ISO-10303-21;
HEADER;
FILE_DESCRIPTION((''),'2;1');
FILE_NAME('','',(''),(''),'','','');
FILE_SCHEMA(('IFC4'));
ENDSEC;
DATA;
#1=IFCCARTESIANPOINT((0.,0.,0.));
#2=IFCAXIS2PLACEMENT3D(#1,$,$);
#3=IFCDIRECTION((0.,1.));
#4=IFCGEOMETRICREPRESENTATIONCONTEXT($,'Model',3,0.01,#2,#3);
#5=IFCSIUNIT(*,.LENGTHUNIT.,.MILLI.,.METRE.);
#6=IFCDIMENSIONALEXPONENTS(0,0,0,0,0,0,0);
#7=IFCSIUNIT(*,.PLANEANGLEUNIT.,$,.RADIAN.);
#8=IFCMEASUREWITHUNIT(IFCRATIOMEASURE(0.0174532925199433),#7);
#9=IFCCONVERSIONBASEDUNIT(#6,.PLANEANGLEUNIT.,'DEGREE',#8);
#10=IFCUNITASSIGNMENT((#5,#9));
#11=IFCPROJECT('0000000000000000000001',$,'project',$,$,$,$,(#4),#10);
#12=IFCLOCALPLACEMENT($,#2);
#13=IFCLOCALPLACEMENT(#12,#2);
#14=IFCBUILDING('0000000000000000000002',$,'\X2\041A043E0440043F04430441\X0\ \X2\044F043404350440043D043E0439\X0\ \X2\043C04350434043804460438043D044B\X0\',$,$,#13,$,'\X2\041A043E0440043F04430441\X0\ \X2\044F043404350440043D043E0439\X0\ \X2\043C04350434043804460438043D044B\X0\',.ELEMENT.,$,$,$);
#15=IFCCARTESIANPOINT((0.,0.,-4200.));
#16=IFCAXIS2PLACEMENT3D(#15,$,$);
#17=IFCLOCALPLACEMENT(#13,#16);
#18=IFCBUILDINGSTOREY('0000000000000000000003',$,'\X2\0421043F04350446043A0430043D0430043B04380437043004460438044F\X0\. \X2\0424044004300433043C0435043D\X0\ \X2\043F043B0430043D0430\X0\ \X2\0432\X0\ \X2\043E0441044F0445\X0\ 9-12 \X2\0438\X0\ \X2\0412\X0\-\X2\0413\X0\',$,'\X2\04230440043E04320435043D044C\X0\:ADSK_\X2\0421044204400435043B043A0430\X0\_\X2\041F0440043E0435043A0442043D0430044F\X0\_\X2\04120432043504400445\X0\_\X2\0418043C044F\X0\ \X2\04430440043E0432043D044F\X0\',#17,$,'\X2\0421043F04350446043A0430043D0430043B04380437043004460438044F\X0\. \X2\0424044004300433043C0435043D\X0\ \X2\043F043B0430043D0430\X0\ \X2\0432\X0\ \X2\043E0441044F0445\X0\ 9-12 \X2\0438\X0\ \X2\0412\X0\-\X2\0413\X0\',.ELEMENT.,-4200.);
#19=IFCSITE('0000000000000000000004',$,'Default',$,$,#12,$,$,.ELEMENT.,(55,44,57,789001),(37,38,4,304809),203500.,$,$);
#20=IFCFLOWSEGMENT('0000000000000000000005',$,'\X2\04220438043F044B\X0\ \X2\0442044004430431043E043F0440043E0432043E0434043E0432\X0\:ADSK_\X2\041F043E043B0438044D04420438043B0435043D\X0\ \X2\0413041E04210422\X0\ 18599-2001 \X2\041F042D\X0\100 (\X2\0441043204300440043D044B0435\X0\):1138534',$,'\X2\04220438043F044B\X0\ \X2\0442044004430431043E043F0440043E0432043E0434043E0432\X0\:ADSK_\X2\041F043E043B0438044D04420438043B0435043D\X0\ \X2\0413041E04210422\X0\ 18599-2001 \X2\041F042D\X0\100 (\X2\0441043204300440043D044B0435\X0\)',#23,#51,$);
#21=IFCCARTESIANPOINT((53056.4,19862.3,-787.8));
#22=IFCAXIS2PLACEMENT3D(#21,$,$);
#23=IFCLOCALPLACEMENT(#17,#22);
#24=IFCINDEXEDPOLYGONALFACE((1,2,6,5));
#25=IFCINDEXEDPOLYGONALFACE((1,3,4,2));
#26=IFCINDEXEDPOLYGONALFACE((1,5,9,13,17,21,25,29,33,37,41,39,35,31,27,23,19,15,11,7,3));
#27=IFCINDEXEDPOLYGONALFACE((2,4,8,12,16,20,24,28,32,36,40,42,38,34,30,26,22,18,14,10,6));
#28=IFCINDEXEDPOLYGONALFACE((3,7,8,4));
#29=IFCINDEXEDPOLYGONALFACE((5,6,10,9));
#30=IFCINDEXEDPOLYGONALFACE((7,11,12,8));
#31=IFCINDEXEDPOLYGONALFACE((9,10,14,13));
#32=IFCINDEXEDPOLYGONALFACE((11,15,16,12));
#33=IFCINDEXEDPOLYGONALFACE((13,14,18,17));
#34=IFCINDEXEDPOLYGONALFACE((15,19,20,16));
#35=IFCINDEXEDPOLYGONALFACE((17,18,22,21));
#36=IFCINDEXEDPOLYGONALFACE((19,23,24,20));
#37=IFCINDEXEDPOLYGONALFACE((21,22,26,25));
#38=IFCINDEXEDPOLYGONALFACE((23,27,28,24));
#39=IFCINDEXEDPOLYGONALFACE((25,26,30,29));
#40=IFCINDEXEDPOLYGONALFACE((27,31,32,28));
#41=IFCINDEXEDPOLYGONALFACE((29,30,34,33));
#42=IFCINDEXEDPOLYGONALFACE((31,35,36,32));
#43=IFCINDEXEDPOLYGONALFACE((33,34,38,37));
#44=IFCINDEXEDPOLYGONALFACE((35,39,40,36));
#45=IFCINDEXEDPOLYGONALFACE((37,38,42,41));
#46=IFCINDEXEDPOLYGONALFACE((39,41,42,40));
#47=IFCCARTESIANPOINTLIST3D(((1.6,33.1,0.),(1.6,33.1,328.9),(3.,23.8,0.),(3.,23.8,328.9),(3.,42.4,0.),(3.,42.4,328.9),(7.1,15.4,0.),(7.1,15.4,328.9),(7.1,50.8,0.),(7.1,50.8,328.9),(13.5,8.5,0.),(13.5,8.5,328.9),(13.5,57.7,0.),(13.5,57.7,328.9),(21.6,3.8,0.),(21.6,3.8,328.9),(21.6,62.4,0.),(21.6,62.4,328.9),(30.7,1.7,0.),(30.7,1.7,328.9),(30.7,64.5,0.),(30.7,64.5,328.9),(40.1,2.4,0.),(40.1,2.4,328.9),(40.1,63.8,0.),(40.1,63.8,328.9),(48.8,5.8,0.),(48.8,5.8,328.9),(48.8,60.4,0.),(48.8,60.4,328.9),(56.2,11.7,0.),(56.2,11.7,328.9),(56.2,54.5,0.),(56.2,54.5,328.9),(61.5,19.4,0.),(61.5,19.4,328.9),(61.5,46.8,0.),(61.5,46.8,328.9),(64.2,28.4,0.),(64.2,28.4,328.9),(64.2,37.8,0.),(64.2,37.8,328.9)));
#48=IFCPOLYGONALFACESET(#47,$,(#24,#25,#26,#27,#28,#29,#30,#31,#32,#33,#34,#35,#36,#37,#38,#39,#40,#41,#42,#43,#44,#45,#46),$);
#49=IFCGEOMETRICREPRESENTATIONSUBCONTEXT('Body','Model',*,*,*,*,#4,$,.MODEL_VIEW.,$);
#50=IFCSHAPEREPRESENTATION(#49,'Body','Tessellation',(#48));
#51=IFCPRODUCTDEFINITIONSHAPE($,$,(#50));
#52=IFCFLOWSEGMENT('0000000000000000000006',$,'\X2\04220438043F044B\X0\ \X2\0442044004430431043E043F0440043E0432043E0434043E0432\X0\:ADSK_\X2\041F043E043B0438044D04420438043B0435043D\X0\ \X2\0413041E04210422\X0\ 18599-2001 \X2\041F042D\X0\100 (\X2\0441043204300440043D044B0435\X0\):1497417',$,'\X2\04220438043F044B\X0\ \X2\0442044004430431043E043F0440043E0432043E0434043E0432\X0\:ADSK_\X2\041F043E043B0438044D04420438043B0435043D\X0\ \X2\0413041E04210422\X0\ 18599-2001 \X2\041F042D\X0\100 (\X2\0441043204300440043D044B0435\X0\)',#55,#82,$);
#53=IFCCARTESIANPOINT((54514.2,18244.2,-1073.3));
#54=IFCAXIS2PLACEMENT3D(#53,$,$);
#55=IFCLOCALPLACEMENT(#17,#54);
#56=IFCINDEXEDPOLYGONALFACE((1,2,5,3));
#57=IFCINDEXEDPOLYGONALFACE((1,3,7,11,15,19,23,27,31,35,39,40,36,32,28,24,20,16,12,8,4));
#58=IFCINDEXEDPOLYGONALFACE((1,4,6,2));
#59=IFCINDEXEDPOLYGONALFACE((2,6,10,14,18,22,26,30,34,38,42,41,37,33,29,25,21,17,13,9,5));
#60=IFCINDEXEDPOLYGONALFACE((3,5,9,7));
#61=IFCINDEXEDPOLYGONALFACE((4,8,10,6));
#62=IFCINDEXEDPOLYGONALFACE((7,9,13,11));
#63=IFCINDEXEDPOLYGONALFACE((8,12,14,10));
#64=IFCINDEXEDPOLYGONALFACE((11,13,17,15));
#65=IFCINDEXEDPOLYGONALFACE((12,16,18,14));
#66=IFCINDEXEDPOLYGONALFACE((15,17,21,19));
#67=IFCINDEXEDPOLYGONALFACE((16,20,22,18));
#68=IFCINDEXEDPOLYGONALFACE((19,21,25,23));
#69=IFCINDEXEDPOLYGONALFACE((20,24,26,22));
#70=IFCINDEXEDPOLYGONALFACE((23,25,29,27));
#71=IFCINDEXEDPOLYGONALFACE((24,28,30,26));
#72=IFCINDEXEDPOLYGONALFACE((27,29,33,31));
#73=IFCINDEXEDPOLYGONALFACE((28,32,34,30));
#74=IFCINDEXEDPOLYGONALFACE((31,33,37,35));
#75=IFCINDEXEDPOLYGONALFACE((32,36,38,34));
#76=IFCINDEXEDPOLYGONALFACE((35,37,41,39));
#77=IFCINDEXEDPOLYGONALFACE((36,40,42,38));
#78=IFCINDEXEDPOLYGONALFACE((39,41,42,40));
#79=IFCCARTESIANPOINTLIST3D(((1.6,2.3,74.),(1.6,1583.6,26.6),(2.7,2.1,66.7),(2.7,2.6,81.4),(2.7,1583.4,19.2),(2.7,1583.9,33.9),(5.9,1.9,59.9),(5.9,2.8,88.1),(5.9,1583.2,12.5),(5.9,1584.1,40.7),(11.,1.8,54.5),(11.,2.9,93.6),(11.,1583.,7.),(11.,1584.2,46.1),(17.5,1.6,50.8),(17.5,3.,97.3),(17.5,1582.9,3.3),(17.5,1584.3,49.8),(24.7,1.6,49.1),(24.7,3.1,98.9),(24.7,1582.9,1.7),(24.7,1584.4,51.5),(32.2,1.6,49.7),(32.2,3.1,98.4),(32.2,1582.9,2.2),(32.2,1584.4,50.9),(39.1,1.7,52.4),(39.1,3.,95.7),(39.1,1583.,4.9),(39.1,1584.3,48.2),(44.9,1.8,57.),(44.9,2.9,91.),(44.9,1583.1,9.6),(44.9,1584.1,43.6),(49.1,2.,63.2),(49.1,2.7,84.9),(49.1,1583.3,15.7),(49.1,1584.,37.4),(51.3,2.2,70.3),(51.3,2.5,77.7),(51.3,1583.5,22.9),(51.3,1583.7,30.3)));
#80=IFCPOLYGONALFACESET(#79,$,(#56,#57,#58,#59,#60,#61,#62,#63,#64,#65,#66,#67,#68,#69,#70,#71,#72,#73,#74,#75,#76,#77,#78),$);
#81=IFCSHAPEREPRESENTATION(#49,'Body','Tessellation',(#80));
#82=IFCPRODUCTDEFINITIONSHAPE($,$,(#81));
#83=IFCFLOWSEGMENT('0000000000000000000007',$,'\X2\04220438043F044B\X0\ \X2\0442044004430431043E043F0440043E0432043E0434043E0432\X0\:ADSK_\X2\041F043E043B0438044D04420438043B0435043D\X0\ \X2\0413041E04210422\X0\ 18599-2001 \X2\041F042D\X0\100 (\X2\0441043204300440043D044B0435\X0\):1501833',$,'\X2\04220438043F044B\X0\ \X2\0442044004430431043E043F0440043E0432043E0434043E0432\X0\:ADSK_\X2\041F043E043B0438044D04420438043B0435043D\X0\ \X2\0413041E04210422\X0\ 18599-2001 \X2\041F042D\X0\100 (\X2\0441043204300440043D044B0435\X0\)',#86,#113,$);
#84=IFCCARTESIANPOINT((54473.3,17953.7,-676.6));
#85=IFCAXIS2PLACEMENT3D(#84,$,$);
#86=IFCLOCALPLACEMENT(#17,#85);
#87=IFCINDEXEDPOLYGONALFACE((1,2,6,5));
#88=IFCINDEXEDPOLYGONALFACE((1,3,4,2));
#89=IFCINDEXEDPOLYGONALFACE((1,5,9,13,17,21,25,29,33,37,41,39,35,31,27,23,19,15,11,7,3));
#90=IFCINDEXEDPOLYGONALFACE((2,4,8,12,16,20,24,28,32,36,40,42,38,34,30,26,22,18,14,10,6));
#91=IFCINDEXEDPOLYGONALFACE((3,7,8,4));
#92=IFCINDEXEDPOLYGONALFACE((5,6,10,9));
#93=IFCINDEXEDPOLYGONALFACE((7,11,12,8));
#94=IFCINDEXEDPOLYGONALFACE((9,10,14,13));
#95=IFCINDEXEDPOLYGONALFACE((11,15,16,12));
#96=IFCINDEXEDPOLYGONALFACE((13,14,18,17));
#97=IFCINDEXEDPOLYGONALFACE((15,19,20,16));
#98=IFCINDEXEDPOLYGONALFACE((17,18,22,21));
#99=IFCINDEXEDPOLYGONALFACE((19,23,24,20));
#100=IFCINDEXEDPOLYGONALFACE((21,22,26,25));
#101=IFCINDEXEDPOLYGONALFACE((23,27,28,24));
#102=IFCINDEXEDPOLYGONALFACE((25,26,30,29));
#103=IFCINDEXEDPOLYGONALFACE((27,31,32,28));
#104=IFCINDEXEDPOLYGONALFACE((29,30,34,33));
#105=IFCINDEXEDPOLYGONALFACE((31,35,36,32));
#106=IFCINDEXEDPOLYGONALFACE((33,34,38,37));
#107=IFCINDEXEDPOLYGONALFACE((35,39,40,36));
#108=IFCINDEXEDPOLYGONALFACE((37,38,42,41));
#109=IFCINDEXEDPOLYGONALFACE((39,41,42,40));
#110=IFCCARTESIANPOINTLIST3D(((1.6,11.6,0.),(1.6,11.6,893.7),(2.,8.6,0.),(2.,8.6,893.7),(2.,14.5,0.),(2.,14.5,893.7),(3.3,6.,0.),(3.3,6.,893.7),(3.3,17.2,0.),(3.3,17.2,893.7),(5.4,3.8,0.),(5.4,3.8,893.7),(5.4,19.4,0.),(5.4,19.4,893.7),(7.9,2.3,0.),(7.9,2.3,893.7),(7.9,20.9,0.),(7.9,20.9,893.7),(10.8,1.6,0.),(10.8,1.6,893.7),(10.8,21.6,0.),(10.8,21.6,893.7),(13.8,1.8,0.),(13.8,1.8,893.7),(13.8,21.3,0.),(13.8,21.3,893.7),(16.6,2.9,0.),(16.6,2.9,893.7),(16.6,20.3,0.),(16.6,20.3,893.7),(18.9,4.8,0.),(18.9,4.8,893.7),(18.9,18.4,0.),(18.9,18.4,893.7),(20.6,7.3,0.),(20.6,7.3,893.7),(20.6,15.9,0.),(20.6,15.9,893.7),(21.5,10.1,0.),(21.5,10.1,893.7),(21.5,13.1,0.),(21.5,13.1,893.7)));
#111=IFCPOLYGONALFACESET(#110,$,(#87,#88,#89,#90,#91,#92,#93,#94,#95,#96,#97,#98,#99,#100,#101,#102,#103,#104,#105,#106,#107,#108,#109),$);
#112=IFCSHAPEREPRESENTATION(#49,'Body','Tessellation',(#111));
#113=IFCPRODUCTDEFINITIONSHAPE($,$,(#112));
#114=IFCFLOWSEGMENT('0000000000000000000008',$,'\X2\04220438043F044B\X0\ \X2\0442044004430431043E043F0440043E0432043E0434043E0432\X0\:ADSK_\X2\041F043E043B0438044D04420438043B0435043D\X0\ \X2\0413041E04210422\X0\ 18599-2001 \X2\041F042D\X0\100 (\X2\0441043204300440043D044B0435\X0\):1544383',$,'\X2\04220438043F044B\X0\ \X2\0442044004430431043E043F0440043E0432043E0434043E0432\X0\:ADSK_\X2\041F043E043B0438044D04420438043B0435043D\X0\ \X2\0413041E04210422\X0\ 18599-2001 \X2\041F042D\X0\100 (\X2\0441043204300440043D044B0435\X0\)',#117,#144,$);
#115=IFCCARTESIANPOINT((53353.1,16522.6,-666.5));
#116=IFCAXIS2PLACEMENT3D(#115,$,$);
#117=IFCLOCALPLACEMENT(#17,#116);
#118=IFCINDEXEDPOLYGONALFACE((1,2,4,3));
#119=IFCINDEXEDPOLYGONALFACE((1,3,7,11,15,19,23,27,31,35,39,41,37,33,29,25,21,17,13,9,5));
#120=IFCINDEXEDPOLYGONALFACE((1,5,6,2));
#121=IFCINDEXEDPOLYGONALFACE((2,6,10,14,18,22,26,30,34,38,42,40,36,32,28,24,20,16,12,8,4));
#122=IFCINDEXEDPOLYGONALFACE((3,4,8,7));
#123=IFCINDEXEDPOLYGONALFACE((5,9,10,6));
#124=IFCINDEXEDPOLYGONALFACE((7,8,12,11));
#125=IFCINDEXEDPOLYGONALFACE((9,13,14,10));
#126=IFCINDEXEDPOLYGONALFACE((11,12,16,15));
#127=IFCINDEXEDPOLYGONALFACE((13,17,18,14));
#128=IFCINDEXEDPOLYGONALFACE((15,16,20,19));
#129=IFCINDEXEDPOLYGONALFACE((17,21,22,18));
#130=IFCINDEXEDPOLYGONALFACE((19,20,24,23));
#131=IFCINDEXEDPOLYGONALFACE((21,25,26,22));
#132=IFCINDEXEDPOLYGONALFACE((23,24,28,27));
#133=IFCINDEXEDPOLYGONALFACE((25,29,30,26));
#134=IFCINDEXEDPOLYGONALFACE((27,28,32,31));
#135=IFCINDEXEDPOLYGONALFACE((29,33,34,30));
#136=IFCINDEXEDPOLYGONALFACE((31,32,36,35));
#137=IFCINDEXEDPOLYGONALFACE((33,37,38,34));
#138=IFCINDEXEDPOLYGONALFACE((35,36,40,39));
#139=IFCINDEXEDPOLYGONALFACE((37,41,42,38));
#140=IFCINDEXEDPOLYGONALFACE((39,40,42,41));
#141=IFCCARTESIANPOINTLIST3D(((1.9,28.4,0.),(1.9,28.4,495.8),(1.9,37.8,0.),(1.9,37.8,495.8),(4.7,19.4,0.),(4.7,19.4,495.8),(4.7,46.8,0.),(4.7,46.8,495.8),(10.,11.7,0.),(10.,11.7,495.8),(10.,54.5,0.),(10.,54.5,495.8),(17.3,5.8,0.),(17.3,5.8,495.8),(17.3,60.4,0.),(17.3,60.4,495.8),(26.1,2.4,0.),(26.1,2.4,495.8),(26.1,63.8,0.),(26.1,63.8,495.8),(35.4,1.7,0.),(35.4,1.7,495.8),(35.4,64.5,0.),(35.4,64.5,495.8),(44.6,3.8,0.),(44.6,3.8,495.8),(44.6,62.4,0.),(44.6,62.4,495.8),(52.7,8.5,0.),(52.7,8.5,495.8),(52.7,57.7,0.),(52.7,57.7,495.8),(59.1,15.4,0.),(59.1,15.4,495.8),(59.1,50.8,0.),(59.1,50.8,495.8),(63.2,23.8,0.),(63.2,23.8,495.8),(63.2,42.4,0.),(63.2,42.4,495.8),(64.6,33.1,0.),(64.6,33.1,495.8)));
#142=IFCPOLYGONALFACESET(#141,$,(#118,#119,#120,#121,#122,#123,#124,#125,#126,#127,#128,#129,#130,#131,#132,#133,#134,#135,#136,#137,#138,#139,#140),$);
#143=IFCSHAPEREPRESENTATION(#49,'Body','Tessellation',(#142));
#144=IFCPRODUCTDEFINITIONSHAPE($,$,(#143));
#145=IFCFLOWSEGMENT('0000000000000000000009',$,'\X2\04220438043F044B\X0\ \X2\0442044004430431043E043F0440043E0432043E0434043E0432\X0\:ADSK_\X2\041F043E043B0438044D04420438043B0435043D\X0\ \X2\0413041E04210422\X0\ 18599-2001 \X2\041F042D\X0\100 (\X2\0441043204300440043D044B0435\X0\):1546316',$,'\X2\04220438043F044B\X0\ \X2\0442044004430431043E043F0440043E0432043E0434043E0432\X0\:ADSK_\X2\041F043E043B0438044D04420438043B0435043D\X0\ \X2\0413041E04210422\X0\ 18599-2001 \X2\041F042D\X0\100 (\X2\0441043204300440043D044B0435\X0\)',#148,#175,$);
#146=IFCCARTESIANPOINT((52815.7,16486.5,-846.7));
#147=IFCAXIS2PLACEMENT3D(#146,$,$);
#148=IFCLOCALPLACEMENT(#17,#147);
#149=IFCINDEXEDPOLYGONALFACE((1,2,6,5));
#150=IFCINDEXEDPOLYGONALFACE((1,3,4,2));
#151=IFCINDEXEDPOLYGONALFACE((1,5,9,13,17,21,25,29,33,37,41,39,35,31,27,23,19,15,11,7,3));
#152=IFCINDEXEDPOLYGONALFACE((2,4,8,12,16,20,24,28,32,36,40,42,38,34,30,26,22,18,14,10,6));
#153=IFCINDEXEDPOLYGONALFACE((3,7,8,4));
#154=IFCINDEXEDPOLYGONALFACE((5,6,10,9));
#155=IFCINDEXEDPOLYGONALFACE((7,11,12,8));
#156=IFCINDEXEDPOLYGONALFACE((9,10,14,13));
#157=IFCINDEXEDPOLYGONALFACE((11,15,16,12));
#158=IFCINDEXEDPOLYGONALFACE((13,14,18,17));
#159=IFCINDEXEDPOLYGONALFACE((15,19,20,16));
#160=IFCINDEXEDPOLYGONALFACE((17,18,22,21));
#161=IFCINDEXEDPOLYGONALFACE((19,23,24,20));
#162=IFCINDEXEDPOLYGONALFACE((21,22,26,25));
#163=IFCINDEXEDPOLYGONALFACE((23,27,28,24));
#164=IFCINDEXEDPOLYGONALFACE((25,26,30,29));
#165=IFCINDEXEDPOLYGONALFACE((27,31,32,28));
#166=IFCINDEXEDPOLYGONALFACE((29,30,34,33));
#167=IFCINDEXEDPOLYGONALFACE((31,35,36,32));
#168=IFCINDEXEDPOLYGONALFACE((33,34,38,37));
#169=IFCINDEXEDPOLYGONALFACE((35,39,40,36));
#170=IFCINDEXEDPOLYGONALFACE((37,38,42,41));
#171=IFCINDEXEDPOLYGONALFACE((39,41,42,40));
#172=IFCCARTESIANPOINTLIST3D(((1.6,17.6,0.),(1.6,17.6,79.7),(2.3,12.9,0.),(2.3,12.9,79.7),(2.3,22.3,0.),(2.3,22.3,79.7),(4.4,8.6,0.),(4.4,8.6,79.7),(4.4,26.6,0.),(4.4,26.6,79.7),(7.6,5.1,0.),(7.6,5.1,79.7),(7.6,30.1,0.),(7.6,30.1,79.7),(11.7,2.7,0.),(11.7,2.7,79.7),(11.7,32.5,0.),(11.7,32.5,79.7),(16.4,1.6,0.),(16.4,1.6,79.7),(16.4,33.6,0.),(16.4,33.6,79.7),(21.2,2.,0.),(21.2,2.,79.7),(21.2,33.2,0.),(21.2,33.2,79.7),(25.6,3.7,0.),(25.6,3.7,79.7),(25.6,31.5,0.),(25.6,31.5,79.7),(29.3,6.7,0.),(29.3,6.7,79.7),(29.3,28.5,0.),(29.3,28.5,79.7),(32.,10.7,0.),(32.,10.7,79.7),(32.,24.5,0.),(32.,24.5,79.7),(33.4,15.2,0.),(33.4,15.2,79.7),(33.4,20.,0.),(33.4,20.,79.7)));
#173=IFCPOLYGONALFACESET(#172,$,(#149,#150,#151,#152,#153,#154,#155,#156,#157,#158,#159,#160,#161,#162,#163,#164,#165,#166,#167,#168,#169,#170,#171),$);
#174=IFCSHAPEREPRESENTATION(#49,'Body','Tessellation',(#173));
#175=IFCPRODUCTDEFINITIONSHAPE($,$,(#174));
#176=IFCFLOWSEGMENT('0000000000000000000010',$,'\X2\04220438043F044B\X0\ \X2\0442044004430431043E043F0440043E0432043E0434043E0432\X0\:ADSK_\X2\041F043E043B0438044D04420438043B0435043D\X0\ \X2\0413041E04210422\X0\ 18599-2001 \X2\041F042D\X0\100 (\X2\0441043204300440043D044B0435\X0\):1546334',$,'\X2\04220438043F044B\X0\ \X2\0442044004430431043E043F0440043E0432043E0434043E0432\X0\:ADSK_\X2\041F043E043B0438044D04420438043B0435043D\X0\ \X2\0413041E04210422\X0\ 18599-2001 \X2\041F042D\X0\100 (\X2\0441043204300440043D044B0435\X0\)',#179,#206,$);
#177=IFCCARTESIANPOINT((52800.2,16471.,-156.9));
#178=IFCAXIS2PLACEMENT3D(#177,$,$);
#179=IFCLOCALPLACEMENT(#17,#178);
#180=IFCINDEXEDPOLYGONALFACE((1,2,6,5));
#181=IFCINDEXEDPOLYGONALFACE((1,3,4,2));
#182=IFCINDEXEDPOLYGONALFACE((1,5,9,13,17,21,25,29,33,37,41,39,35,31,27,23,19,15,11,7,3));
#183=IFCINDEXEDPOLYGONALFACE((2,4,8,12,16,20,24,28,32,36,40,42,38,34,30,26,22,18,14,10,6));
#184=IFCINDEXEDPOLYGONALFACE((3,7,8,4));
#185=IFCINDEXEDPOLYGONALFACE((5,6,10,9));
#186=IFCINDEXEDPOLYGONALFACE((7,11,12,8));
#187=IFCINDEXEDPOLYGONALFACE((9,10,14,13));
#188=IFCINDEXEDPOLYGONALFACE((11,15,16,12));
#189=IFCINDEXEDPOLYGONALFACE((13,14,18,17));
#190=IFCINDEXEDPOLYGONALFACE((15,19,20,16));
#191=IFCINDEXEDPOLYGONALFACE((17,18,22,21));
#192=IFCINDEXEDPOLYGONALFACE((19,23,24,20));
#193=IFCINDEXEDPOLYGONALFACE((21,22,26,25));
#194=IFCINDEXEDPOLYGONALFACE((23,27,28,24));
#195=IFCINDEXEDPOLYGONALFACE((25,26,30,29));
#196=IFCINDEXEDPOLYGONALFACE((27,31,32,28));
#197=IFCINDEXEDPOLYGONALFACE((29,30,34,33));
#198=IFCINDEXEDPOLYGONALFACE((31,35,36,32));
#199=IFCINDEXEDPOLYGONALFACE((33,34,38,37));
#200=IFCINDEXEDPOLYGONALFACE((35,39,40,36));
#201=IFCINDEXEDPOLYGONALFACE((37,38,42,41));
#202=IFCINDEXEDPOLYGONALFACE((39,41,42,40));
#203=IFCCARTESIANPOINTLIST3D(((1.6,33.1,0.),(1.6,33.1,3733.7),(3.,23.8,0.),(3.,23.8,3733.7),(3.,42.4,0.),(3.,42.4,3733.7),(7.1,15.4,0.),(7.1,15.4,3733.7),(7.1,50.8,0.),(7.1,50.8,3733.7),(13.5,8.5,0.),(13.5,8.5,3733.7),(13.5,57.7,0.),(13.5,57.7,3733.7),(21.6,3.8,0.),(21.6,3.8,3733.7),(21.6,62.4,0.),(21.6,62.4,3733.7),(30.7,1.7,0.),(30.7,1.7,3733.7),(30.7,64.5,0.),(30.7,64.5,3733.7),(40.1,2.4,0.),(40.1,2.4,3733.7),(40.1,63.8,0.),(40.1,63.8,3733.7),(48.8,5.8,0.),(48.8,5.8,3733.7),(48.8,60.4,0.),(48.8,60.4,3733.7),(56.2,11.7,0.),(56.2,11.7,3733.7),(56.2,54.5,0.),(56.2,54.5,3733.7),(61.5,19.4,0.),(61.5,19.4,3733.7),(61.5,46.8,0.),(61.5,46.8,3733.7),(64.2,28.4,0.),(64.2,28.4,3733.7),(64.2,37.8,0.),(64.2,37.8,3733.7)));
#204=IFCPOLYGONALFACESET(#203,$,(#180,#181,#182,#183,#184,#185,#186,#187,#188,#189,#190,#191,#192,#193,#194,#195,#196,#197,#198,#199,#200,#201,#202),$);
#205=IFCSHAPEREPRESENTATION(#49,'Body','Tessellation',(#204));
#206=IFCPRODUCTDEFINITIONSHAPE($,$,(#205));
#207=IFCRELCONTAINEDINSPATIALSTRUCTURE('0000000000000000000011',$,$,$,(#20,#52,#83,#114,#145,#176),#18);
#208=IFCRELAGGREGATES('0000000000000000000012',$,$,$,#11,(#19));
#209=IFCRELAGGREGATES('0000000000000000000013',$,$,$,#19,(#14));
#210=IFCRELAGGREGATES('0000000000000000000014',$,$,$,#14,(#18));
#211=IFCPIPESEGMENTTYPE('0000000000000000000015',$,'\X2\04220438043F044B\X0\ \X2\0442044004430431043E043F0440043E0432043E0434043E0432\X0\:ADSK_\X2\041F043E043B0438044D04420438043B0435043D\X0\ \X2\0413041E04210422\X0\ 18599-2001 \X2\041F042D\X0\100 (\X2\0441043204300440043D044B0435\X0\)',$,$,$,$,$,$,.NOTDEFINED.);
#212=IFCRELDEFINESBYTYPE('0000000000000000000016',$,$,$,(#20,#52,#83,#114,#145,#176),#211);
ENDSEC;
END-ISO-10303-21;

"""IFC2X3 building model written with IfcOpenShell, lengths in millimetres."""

from ifc_helpers import new_model, entity, si_unit, converted_unit, direction, frame, frame_2d, origin, origin_2d_with_axis, place, context, subcontext, project, spatial, circle, extrude, type_object, element, save


model = new_model("IFC2X3")

# Units and contexts
model_context = context("Model", 3, precision=0.01, world=origin(), true_north=direction((0.0, 1.0)))
body_context = subcontext(model_context, "Body", "Model", "MODEL_VIEW")
ifc_project = project(units=[si_unit("LENGTHUNIT", "METRE", prefix="MILLI"), converted_unit("PLANEANGLEUNIT", "DEGREE", entity("IfcRatioMeasure", 0.0174532925199433), si_unit("PLANEANGLEUNIT", "RADIAN"), dimensions=[0, 0, 0, 0, 0, 0, 0])], contexts=[model_context])

# Site, building, storey
site_placement = place(None, frame((0.0, 0.0, 0.0)))
site = spatial("IfcSite", under=ifc_project, at=site_placement, Name="Default", CompositionType="ELEMENT", RefLatitude=(55, 44, 57, 789001), RefLongitude=(37, 38, 4, 304809), RefElevation=203500.0)
building_placement = place(site_placement, origin())
building = spatial("IfcBuilding", under=site, at=building_placement, Name="Корпус ядерной медицины", LongName="Корпус ядерной медицины", CompositionType="ELEMENT")
storey_placement = place(building_placement, frame((0.0, 0.0, -4200.0)))
storey = spatial("IfcBuildingStorey", under=building, at=storey_placement, Name="Спецканализация. Фрагмен плана в осях 9-12 и В-Г", ObjectType="Уровень:ADSK_Стрелка_Проектная_Вверх_Имя уровня", LongName="Спецканализация. Фрагмен плана в осях 9-12 и В-Г", CompositionType="ELEMENT", Elevation=-4200.0)

# Flow segments
pipe_segment_type = type_object("IfcPipeSegmentType", Name="Типы трубопроводов:ADSK_Полиэтилен ГОСТ 18599-2001 ПЭ100 (сварные)", PredefinedType="NOTDEFINED")
flow_segment_1_placement = place(storey_placement, frame((53056.4, 19862.3, -787.8)))
element("IfcFlowSegment", 1, at=flow_segment_1_placement, inside=storey, type_object=pipe_segment_type, Name="Типы трубопроводов:ADSK_Полиэтилен ГОСТ 18599-2001 ПЭ100 (сварные):1138534", ObjectType="Типы трубопроводов:ADSK_Полиэтилен ГОСТ 18599-2001 ПЭ100 (сварные)", context=body_context, shape_type="SweptSolid", body=[
    extrude(circle(Radius=31.5, at=origin_2d_with_axis()), frame((33.1, 33.1, 0.0), z_axis=(0.0, 0.0, 1.0), x_axis=(-1.0, 0.0, 0.0)), (0.0, 0.0, 1.0), 328.9),
])
flow_segment_2_placement = place(storey_placement, frame((54514.2, 18244.2, -1073.3)))
element("IfcFlowSegment", 2, at=flow_segment_2_placement, inside=storey, type_object=pipe_segment_type, Name="Типы трубопроводов:ADSK_Полиэтилен ГОСТ 18599-2001 ПЭ100 (сварные):1497417", ObjectType="Типы трубопроводов:ADSK_Полиэтилен ГОСТ 18599-2001 ПЭ100 (сварные)", context=body_context, shape_type="SweptSolid", body=[
    extrude(circle(Radius=25.0, at=origin_2d_with_axis()), frame((26.6, 2.3, 74.0), z_axis=(0.0, 0.99955, -0.029987), x_axis=(-1.0, 0.0, 0.0)), (0.0, 0.0, 1.0), 1582.0),
])
flow_segment_3_placement = place(storey_placement, frame((54473.3, 17953.7, -676.6)))
element("IfcFlowSegment", 3, at=flow_segment_3_placement, inside=storey, type_object=pipe_segment_type, Name="Типы трубопроводов:ADSK_Полиэтилен ГОСТ 18599-2001 ПЭ100 (сварные):1501833", ObjectType="Типы трубопроводов:ADSK_Полиэтилен ГОСТ 18599-2001 ПЭ100 (сварные)", context=body_context, shape_type="SweptSolid", body=[
    extrude(circle(Radius=10.0, at=frame_2d((0.0, 0.0), x_axis=(1.0, 0.0))), frame((11.6, 11.6, 0.0), z_axis=(0.0, 0.0, 1.0), x_axis=(-1.0, 0.0, 0.0)), (0.0, 0.0, 1.0), 893.7),
])
flow_segment_4_placement = place(storey_placement, frame((53353.1, 16522.6, -666.5)))
element("IfcFlowSegment", 4, at=flow_segment_4_placement, inside=storey, type_object=pipe_segment_type, Name="Типы трубопроводов:ADSK_Полиэтилен ГОСТ 18599-2001 ПЭ100 (сварные):1544383", ObjectType="Типы трубопроводов:ADSK_Полиэтилен ГОСТ 18599-2001 ПЭ100 (сварные)", context=body_context, shape_type="SweptSolid", body=[
    extrude(circle(Radius=31.5, at=origin_2d_with_axis()), frame((33.1, 33.1, 0.0)), (0.0, 0.0, 1.0), 495.8),
])
flow_segment_5_placement = place(storey_placement, frame((52815.7, 16486.5, -846.7)))
element("IfcFlowSegment", 5, at=flow_segment_5_placement, inside=storey, type_object=pipe_segment_type, Name="Типы трубопроводов:ADSK_Полиэтилен ГОСТ 18599-2001 ПЭ100 (сварные):1546316", ObjectType="Типы трубопроводов:ADSK_Полиэтилен ГОСТ 18599-2001 ПЭ100 (сварные)", context=body_context, shape_type="SweptSolid", body=[
    extrude(circle(Radius=16.0, at=origin_2d_with_axis()), frame((17.6, 17.6, 0.0), z_axis=(0.0, 0.0, 1.0), x_axis=(-1.0, 0.0, 0.0)), (0.0, 0.0, 1.0), 79.7),
])
flow_segment_6_placement = place(storey_placement, frame((52800.2, 16471.0, -156.9)))
element("IfcFlowSegment", 6, at=flow_segment_6_placement, inside=storey, type_object=pipe_segment_type, Name="Типы трубопроводов:ADSK_Полиэтилен ГОСТ 18599-2001 ПЭ100 (сварные):1546334", ObjectType="Типы трубопроводов:ADSK_Полиэтилен ГОСТ 18599-2001 ПЭ100 (сварные)", context=body_context, shape_type="SweptSolid", body=[
    extrude(circle(Radius=31.5, at=frame_2d((0.0, 0.0), x_axis=(1.0, 0.0))), frame((33.1, 33.1, 0.0), z_axis=(0.0, 0.0, 1.0), x_axis=(-1.0, 0.0, 0.0)), (0.0, 0.0, 1.0), 3733.7),
])

save(model, "model.ifc")
